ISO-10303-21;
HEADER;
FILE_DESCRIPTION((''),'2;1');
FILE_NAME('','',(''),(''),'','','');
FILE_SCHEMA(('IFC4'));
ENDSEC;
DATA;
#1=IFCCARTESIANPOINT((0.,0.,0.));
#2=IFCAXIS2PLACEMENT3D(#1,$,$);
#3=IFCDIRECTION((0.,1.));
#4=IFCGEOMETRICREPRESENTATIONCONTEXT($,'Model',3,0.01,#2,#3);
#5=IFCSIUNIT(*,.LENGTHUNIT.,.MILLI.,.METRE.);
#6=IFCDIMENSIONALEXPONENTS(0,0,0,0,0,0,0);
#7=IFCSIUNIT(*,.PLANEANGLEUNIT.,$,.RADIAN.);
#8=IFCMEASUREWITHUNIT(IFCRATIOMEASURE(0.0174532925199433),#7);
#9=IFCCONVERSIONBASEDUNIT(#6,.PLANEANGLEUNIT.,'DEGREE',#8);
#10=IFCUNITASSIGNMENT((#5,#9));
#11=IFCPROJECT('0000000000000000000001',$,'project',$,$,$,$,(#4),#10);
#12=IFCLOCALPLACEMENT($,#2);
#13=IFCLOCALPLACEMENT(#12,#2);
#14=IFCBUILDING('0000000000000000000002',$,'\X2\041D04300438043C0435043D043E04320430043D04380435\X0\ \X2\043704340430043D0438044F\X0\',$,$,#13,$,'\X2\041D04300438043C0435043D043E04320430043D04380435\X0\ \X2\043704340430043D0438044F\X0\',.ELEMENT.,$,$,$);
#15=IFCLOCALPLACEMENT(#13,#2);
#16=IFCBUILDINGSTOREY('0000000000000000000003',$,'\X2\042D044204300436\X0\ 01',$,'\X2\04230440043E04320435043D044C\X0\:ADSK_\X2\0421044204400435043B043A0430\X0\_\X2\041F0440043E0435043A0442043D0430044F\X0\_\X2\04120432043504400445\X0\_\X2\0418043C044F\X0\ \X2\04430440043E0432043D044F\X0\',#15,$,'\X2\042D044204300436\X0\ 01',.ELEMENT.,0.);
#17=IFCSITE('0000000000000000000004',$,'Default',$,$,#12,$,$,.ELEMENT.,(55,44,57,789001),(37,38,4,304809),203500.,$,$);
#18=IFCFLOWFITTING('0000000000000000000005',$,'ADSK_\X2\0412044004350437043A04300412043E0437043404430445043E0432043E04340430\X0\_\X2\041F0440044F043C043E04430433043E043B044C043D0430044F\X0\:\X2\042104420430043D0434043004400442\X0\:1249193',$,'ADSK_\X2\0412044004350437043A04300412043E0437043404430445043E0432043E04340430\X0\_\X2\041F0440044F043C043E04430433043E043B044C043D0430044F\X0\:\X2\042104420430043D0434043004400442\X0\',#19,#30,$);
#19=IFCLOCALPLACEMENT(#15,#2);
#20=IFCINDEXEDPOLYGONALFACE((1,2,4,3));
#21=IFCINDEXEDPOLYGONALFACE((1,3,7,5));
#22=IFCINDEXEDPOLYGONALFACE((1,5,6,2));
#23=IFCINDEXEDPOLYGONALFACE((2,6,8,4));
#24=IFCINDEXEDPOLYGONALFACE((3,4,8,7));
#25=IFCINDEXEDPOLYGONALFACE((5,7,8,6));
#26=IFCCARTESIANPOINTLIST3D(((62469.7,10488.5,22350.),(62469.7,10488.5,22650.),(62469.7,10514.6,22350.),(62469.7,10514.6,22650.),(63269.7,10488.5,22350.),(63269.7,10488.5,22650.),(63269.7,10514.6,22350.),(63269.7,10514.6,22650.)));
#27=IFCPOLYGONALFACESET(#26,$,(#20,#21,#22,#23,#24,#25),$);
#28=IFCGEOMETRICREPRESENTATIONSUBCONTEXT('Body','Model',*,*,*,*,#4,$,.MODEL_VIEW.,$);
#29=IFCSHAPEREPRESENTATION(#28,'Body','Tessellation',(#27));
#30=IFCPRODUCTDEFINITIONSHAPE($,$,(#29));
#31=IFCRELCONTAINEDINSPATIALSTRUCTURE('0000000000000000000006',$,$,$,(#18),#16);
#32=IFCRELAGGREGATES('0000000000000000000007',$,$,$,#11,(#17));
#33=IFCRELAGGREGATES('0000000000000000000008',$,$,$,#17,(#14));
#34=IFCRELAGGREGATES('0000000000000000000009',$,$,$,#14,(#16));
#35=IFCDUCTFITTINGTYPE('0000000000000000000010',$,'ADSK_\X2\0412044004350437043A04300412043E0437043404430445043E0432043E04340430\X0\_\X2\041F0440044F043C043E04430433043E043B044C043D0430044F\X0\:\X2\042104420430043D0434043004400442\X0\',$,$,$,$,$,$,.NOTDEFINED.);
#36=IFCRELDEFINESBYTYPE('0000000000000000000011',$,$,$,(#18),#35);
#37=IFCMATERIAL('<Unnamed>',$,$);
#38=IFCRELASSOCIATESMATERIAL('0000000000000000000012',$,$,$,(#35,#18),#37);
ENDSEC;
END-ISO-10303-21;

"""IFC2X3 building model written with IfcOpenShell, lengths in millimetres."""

from ifc_helpers import new_model, entity, si_unit, converted_unit, direction, frame, origin, origin_2d_with_axis, place, context, subcontext, project, spatial, rectangle, extrude, source, transform, mapped, material, type_object, type_shapes, element, save


model = new_model("IFC2X3")

# Units and contexts
model_context = context("Model", 3, precision=0.01, world=origin(), true_north=direction((0.0, 1.0)))
body_context = subcontext(model_context, "Body", "Model", "MODEL_VIEW")
ifc_project = project(units=[si_unit("LENGTHUNIT", "METRE", prefix="MILLI"), converted_unit("PLANEANGLEUNIT", "DEGREE", entity("IfcRatioMeasure", 0.0174532925199433), si_unit("PLANEANGLEUNIT", "RADIAN"), dimensions=[0, 0, 0, 0, 0, 0, 0])], contexts=[model_context])

# Site, building, storey
site_placement = place(None, origin())
site = spatial("IfcSite", under=ifc_project, at=site_placement, Name="Default", CompositionType="ELEMENT", RefLatitude=(55, 44, 57, 789001), RefLongitude=(37, 38, 4, 304809), RefElevation=203500.0)
building_placement = place(site_placement, origin())
building = spatial("IfcBuilding", under=site, at=building_placement, Name="Наименование здания", LongName="Наименование здания", CompositionType="ELEMENT")
storey_placement = place(building_placement, origin())
storey = spatial("IfcBuildingStorey", under=building, at=storey_placement, Name="Этаж 01", ObjectType="Уровень:ADSK_Стрелка_Проектная_Вверх_Имя уровня", LongName="Этаж 01", CompositionType="ELEMENT", Elevation=0.0)

# Shared definitions
ifc_material_1 = material(Name="<Unnamed>")

# Flow fitting
duct_fitting_type_1 = type_object("IfcDuctFittingType", Name="ADSK_ВрезкаВоздуховода_Прямоугольная:Стандарт", PredefinedType="NOTDEFINED", material=ifc_material_1)
shared_shape_1 = source(origin(), body_context, "Body", "SweptSolid", [
    extrude(rectangle(XDim=26.1, YDim=300.0, at=origin_2d_with_axis()), frame((7.0, 0.0, -400.0)), (0.0, 0.0, 1.0), 800.0),
])
type_shapes(duct_fitting_type_1, [shared_shape_1])
flow_fitting_1_placement = place(storey_placement, frame((62869.7, 10508.5, 22500.0), z_axis=(-1.0, 0.000003, 0.0), x_axis=(-0.000003, -1.0, 0.0)))
element("IfcFlowFitting", 1, at=flow_fitting_1_placement, inside=storey, type_object=duct_fitting_type_1, material=ifc_material_1, Name="ADSK_ВрезкаВоздуховода_Прямоугольная:Стандарт:1249193", ObjectType="ADSK_ВрезкаВоздуховода_Прямоугольная:Стандарт", context=body_context, shape_type="MappedRepresentation", body=[
    mapped(shared_shape_1, transform((0.0, 0.0, 0.0), scale=1.0)),
])

save(model, "model.ifc")
